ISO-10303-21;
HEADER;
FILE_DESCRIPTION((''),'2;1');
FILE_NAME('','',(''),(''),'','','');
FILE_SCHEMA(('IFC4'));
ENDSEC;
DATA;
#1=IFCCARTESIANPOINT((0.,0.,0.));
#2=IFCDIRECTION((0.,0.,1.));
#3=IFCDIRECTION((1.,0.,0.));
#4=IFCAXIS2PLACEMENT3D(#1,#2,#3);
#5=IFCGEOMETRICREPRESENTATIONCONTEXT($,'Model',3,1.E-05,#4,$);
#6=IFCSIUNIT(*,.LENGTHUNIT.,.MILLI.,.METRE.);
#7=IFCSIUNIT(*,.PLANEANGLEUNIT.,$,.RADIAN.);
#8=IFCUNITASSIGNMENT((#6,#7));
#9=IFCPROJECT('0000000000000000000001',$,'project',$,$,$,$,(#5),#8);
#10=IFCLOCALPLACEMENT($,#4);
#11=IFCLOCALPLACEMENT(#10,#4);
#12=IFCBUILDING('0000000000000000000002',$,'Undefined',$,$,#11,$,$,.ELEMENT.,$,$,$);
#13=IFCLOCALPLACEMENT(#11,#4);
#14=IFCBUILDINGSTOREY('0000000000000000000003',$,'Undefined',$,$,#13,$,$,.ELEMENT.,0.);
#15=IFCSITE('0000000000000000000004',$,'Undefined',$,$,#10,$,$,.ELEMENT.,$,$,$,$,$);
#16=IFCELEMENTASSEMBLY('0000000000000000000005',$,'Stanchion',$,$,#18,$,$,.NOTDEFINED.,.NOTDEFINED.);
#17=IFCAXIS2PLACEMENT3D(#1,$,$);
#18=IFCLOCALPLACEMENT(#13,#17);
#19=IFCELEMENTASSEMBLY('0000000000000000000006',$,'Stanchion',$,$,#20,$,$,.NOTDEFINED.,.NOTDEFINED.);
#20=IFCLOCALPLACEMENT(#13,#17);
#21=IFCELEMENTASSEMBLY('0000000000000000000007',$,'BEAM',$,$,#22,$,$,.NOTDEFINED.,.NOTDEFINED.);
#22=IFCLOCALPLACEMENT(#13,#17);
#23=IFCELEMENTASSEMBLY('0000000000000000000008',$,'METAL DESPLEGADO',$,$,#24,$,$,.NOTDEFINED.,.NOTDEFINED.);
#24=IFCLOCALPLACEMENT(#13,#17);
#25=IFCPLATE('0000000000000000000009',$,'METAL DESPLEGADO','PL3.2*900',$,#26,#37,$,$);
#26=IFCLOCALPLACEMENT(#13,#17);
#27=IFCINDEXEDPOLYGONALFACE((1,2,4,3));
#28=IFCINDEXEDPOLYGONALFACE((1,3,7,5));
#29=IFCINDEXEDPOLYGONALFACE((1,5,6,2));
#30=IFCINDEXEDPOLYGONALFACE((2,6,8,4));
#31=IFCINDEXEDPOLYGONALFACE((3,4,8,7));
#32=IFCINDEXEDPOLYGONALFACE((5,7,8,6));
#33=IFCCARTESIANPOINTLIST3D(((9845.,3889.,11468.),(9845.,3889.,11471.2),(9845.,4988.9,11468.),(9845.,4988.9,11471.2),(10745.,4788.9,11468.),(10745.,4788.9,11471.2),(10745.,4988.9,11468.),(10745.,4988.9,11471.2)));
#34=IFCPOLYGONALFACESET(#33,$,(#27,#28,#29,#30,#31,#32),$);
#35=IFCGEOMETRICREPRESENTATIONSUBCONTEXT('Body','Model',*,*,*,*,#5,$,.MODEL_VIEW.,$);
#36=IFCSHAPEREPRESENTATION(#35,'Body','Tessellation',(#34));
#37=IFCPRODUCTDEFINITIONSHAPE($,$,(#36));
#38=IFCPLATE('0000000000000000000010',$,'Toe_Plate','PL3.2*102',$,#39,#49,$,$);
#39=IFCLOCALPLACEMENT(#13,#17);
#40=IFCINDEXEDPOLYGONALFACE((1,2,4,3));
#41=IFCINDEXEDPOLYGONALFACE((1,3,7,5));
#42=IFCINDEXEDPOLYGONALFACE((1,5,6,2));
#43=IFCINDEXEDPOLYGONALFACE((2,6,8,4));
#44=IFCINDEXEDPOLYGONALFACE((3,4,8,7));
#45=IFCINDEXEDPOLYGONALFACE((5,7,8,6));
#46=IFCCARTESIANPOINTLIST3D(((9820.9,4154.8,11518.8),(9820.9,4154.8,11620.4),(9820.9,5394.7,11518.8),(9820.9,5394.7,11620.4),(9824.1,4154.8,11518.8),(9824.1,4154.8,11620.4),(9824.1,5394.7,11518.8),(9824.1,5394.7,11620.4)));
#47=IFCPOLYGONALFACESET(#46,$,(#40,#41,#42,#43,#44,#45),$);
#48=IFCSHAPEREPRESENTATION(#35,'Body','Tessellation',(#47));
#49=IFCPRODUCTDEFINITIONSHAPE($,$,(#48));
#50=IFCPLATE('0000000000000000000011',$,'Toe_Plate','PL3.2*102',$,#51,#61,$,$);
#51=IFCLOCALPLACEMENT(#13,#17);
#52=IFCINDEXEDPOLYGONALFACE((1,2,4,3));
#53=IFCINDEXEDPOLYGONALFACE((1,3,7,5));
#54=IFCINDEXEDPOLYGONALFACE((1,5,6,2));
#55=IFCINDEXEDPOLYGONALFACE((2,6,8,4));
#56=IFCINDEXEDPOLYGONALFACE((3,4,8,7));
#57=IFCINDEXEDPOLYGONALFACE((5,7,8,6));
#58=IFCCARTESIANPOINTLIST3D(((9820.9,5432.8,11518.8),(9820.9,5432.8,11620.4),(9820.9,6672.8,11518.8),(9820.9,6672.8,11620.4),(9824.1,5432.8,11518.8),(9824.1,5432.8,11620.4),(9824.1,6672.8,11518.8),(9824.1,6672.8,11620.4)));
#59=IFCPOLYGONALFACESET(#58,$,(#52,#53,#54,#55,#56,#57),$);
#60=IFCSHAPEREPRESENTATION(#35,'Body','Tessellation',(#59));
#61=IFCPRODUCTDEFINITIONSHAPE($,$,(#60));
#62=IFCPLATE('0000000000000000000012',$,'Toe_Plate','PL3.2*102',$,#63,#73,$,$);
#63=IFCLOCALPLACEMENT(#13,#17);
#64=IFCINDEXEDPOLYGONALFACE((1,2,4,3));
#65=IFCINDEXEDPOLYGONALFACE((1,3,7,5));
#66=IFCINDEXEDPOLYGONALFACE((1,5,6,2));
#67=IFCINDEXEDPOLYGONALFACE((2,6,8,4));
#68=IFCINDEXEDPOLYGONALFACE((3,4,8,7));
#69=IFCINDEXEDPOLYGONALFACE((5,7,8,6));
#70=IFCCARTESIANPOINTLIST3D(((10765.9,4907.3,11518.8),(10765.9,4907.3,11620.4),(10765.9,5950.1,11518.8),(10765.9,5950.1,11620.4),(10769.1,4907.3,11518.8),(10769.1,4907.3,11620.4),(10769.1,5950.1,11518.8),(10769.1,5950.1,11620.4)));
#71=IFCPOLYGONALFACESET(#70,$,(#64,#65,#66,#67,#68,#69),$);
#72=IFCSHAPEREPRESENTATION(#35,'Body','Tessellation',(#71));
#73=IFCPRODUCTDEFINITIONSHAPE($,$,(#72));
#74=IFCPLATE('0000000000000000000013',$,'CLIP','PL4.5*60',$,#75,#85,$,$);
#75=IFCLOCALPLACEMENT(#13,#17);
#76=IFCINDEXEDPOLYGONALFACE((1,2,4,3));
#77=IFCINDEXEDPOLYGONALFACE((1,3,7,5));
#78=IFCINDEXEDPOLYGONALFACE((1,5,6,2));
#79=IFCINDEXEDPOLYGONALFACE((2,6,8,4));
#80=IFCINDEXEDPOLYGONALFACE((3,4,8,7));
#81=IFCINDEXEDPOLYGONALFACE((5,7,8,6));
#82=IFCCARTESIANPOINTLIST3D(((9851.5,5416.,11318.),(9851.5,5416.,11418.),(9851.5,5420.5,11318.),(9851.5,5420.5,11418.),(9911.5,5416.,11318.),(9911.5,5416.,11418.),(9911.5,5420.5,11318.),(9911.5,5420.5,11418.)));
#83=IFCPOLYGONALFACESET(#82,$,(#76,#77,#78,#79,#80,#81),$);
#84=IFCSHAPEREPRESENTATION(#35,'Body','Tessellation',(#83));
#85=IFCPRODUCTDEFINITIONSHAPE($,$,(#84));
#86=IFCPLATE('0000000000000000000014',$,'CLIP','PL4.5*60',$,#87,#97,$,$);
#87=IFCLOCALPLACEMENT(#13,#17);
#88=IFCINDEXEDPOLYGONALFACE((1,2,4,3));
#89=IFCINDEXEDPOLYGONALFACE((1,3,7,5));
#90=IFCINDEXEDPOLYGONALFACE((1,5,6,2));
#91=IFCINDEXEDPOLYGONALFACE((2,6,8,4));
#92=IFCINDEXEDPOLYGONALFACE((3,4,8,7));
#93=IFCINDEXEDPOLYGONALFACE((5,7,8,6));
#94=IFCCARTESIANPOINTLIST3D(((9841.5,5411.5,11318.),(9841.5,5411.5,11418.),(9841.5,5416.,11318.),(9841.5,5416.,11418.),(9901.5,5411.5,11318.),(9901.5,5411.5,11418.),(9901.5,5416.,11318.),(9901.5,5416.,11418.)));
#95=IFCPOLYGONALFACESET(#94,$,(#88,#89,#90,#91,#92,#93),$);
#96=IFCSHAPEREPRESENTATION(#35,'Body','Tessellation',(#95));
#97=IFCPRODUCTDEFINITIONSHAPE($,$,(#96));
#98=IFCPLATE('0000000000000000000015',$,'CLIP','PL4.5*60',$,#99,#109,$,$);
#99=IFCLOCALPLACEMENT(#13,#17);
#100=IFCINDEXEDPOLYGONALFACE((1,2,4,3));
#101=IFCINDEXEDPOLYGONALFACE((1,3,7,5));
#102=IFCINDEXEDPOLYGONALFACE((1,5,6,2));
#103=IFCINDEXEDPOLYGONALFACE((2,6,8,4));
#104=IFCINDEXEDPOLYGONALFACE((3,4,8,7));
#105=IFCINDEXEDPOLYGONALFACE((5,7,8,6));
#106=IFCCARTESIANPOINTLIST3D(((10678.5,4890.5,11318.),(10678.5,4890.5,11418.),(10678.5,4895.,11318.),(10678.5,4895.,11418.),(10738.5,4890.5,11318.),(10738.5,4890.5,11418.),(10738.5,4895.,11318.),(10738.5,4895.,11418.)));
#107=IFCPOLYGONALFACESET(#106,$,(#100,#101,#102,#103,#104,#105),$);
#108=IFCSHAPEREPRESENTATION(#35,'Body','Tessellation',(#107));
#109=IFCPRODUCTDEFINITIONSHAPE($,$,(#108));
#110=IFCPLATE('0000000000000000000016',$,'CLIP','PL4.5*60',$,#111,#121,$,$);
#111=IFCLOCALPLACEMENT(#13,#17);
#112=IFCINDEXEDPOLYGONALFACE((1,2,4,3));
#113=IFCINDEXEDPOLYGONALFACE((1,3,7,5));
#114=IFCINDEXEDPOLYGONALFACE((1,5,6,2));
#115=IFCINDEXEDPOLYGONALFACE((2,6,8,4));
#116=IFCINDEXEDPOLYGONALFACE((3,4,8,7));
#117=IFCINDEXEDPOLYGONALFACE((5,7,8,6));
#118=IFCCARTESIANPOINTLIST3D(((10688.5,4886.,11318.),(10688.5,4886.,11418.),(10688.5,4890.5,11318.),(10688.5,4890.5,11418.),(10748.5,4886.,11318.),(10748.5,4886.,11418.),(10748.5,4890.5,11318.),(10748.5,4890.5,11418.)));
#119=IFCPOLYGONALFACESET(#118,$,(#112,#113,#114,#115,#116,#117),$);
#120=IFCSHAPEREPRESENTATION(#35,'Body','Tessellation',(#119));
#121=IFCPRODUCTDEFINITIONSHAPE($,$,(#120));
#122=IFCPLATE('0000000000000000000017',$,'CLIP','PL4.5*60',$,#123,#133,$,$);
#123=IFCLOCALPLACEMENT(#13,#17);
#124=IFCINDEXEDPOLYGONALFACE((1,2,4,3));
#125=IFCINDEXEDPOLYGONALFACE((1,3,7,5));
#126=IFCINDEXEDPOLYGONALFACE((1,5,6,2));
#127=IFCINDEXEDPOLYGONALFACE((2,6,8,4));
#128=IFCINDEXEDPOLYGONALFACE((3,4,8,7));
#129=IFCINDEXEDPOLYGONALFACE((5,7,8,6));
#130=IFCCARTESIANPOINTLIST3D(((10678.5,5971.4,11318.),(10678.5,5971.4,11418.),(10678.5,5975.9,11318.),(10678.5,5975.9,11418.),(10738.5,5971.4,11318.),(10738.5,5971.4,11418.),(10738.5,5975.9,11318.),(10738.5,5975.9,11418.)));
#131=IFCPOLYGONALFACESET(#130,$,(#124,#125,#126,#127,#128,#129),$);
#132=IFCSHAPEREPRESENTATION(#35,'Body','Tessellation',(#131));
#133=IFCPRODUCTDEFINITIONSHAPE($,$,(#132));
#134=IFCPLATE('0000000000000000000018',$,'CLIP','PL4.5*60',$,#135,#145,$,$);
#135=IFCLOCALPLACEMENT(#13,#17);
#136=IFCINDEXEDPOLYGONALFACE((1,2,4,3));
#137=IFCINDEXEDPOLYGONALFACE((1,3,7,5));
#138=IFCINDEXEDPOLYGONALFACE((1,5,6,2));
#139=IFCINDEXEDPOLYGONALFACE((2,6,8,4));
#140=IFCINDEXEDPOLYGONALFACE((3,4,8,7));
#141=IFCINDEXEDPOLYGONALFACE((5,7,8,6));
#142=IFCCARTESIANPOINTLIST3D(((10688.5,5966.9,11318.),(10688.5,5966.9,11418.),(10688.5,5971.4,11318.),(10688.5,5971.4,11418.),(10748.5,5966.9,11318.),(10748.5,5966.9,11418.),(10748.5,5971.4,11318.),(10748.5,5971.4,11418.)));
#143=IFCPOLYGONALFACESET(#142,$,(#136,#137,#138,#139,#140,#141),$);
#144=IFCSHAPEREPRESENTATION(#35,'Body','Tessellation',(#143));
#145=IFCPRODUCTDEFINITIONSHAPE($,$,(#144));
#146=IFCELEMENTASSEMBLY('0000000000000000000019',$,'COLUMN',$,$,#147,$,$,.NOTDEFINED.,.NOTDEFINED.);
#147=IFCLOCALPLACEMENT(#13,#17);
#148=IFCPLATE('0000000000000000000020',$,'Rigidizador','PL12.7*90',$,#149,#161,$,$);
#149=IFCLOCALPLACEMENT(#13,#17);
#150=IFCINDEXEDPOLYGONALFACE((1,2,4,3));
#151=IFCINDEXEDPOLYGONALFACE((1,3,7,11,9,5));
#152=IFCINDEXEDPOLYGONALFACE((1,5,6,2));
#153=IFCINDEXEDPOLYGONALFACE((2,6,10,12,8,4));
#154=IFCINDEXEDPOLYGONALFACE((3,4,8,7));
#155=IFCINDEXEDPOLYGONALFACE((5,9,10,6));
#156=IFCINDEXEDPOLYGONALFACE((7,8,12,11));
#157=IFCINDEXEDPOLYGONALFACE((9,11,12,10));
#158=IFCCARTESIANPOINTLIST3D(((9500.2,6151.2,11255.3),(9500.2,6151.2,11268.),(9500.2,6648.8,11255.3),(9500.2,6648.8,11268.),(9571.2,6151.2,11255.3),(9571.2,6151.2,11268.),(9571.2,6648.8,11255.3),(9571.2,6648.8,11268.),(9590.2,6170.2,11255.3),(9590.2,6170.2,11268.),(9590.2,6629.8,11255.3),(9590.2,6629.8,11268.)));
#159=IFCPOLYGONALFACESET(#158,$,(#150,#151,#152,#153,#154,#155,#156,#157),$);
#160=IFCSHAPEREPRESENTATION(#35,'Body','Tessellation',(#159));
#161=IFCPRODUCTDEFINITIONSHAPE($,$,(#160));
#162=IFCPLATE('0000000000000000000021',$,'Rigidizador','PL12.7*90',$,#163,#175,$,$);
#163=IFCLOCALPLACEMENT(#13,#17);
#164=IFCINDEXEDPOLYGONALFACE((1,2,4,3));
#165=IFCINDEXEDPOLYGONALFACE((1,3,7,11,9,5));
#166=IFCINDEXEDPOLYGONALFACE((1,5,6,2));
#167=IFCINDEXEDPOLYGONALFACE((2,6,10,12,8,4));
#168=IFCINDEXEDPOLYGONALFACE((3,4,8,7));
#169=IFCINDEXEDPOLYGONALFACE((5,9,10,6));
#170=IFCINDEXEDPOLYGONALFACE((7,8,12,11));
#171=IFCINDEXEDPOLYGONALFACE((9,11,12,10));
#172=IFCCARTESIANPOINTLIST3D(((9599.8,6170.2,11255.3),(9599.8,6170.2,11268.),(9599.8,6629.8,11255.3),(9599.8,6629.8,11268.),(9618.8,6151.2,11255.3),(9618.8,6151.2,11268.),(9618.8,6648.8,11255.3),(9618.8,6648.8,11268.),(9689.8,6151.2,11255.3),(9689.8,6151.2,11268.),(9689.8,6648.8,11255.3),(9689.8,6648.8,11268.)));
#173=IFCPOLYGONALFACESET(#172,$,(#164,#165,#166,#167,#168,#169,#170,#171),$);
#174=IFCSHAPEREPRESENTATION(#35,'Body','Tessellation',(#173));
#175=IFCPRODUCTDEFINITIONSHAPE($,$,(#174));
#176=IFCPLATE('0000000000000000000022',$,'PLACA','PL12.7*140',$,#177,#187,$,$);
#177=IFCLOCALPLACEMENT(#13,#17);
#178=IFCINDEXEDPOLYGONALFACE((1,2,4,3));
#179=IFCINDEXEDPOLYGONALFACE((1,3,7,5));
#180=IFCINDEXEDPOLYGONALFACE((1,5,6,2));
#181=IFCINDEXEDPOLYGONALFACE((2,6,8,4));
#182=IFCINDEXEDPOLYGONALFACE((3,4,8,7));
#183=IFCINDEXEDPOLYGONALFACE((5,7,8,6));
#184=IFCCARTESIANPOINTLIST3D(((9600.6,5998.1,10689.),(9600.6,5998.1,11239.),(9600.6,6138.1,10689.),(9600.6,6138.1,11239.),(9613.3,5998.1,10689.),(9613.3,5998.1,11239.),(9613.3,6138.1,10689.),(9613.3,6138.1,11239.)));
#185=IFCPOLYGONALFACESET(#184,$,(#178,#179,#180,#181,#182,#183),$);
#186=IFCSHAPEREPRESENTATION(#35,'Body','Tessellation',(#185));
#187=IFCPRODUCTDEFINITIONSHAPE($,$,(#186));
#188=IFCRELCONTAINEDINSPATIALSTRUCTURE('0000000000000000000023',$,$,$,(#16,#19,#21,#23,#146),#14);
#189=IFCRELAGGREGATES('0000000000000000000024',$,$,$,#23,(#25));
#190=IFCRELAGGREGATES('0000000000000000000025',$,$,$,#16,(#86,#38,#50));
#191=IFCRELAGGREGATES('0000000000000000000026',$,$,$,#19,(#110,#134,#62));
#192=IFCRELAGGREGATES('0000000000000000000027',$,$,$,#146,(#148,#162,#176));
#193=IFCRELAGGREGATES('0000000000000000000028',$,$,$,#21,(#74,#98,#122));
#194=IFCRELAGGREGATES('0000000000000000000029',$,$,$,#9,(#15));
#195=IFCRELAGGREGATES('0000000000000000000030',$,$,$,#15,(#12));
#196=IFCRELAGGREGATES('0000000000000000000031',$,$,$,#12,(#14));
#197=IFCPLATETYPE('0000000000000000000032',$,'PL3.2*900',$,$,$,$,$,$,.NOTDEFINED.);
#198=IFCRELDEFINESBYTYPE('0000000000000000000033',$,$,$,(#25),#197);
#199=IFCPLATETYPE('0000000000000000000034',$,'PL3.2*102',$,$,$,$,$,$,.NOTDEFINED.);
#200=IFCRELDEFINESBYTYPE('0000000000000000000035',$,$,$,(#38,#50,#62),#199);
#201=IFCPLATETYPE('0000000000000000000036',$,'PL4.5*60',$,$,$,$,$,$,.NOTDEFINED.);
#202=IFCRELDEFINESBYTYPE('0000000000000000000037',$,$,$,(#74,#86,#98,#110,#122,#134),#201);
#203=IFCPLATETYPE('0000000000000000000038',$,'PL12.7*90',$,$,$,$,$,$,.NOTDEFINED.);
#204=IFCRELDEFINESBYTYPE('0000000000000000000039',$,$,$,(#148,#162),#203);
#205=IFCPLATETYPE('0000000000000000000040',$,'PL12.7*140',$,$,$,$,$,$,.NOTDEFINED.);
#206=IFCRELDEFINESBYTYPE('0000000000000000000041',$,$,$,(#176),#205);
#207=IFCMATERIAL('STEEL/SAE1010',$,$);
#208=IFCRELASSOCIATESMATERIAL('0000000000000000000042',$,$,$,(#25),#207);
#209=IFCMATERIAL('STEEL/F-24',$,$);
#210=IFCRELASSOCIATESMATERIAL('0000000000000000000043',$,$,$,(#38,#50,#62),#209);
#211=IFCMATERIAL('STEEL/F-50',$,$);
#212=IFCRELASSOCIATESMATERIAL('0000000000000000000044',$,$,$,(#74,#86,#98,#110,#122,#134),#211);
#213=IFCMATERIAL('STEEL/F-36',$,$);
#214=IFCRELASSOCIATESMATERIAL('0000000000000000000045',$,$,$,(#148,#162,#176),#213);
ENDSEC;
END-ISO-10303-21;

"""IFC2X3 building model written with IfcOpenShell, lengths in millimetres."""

from ifc_helpers import new_model, si_unit, frame, origin_with_axes, place, context, subcontext, project, spatial, polyline, outline, extrude, material, type_object, element, aggregate, save


model = new_model("IFC2X3")

# Units and contexts
model_context = context("Model", 3, precision=1e-05, world=origin_with_axes())
body_context = subcontext(model_context, "Body", "Model", "MODEL_VIEW")
ifc_project = project(units=[si_unit("LENGTHUNIT", "METRE", prefix="MILLI"), si_unit("PLANEANGLEUNIT", "RADIAN")], contexts=[model_context])

# Site, building, storey
site_placement = place(None, origin_with_axes())
site = spatial("IfcSite", under=ifc_project, at=site_placement, Name="Undefined", CompositionType="ELEMENT")
building_placement = place(site_placement, origin_with_axes())
building = spatial("IfcBuilding", under=site, at=building_placement, Name="Undefined", CompositionType="ELEMENT")
storey_placement = place(building_placement, origin_with_axes())
storey = spatial("IfcBuildingStorey", under=building, at=storey_placement, Name="Undefined", CompositionType="ELEMENT", Elevation=0.0)

# Element assemblies
assembly_1_placement = place(storey_placement, origin_with_axes())
assembly_1 = element("IfcElementAssembly", 1, at=assembly_1_placement, inside=storey, Name="Stanchion", AssemblyPlace="NOTDEFINED", PredefinedType="NOTDEFINED")
ifc_material_1 = material(Name="STEEL/F-24")
assembly_2_placement = place(storey_placement, origin_with_axes())
assembly_2 = element("IfcElementAssembly", 2, at=assembly_2_placement, inside=storey, Name="Stanchion", AssemblyPlace="NOTDEFINED", PredefinedType="NOTDEFINED")

# Element assembly
assembly_3_placement = place(storey_placement, origin_with_axes())
assembly_3 = element("IfcElementAssembly", 3, at=assembly_3_placement, inside=storey, Name="BEAM", AssemblyPlace="NOTDEFINED", PredefinedType="NOTDEFINED")

# Element assembly, plate
assembly_4_placement = place(storey_placement, origin_with_axes())
assembly_4 = element("IfcElementAssembly", 4, at=assembly_4_placement, inside=storey, Name="METAL DESPLEGADO", AssemblyPlace="NOTDEFINED", PredefinedType="NOTDEFINED")
ifc_material_2 = material(Name="STEEL/SAE1010")
plate_type_1 = type_object("IfcPlateType", Name="PL3.2*900", PredefinedType="NOTDEFINED")
plate_1_placement = place(assembly_4_placement, frame((9845.0, 4988.9, 11469.6), z_axis=(0.0, 0.0, 1.0), x_axis=(0.0, -1.0, 0.0)))
plate_1 = element("IfcPlate", 5, at=plate_1_placement, type_object=plate_type_1, material=ifc_material_2, Name="METAL DESPLEGADO", Description="PL3.2*900", context=body_context, shape_type="SweptSolid", body=[
    extrude(outline(polyline([(0.0, 0.0), (1100.0, 0.0), (200.0, 900.0), (0.0, 900.0), (0.0, 0.0)])), frame((0.0, 0.0, -1.6), z_axis=(0.0, 0.0, 1.0), x_axis=(1.0, 0.0, 0.0)), (0.0, 0.0, 1.0), 3.2),
])
aggregate(assembly_4, [plate_1])

# Plates
plate_type_2 = type_object("IfcPlateType", Name="PL3.2*102", PredefinedType="NOTDEFINED")
plate_2_placement = place(assembly_1_placement, frame((9822.5, 5394.7, 11518.8), z_axis=(-1.0, 0.0, 0.0), x_axis=(0.0, -1.0, 0.0)))
plate_2 = element("IfcPlate", 6, at=plate_2_placement, type_object=plate_type_2, material=ifc_material_1, Name="Toe_Plate", Description="PL3.2*102", context=body_context, shape_type="SweptSolid", body=[
    extrude(outline(polyline([(0.0, 0.0), (1239.9, 0.0), (1239.9, 101.6), (0.0, 101.6), (0.0, 0.0)])), frame((0.0, 0.0, -1.6), z_axis=(0.0, 0.0, 1.0), x_axis=(1.0, 0.0, 0.0)), (0.0, 0.0, 1.0), 3.2),
])
plate_3_placement = place(assembly_1_placement, frame((9822.5, 6672.8, 11518.8), z_axis=(-1.0, 0.0, 0.0), x_axis=(0.0, -1.0, 0.0)))
plate_3 = element("IfcPlate", 7, at=plate_3_placement, type_object=plate_type_2, material=ifc_material_1, Name="Toe_Plate", Description="PL3.2*102", context=body_context, shape_type="SweptSolid", body=[
    extrude(outline(polyline([(0.0, 0.0), (1239.9, 0.0), (1239.9, 101.6), (0.0, 101.6), (0.0, 0.0)])), frame((0.0, 0.0, -1.6), z_axis=(0.0, 0.0, 1.0), x_axis=(1.0, 0.0, 0.0)), (0.0, 0.0, 1.0), 3.2),
])
plate_4_placement = place(assembly_2_placement, frame((10767.5, 5950.1, 11518.8), z_axis=(-1.0, 0.0, 0.0), x_axis=(0.0, -1.0, 0.0)))
plate_4 = element("IfcPlate", 8, at=plate_4_placement, type_object=plate_type_2, material=ifc_material_1, Name="Toe_Plate", Description="PL3.2*102", context=body_context, shape_type="SweptSolid", body=[
    extrude(outline(polyline([(0.0, 0.0), (1042.8, 0.0), (1042.8, 101.6), (0.0, 101.6), (0.0, 0.0)])), frame((0.0, 0.0, -1.6), z_axis=(0.0, 0.0, 1.0), x_axis=(1.0, 0.0, 0.0)), (0.0, 0.0, 1.0), 3.2),
])
ifc_material_3 = material(Name="STEEL/F-50")
plate_type_3 = type_object("IfcPlateType", Name="PL4.5*60", PredefinedType="NOTDEFINED")
plate_5_placement = place(assembly_3_placement, frame((9851.5, 5418.3, 11318.0), z_axis=(0.0, -1.0, 0.0), x_axis=(1.0, 0.0, 0.0)))
plate_5 = element("IfcPlate", 9, at=plate_5_placement, type_object=plate_type_3, material=ifc_material_3, Name="CLIP", Description="PL4.5*60", context=body_context, shape_type="SweptSolid", body=[
    extrude(outline(polyline([(0.0, 0.0), (60.0, 0.0), (60.0, 100.0), (0.0, 100.0), (0.0, 0.0)])), frame((0.0, 0.0, -2.2), z_axis=(0.0, 0.0, 1.0), x_axis=(1.0, 0.0, 0.0)), (0.0, 0.0, 1.0), 4.5),
])
plate_6_placement = place(assembly_1_placement, frame((9841.5, 5413.8, 11318.0), z_axis=(0.0, -1.0, 0.0), x_axis=(1.0, 0.0, 0.0)))
plate_6 = element("IfcPlate", 10, at=plate_6_placement, type_object=plate_type_3, material=ifc_material_3, Name="CLIP", Description="PL4.5*60", context=body_context, shape_type="SweptSolid", body=[
    extrude(outline(polyline([(0.0, 0.0), (60.0, 0.0), (60.0, 100.0), (0.0, 100.0), (0.0, 0.0)])), frame((0.0, 0.0, -2.2), z_axis=(0.0, 0.0, 1.0), x_axis=(1.0, 0.0, 0.0)), (0.0, 0.0, 1.0), 4.5),
])
aggregate(assembly_1, [plate_6, plate_2, plate_3])
plate_7_placement = place(assembly_3_placement, frame((10738.5, 4892.8, 11318.0), z_axis=(0.0, 1.0, 0.0), x_axis=(-1.0, 0.0, 0.0)))
plate_7 = element("IfcPlate", 11, at=plate_7_placement, type_object=plate_type_3, material=ifc_material_3, Name="CLIP", Description="PL4.5*60", context=body_context, shape_type="SweptSolid", body=[
    extrude(outline(polyline([(0.0, 0.0), (60.0, 0.0), (60.0, 100.0), (0.0, 100.0), (0.0, 0.0)])), frame((0.0, 0.0, -2.2), z_axis=(0.0, 0.0, 1.0), x_axis=(1.0, 0.0, 0.0)), (0.0, 0.0, 1.0), 4.5),
])
plate_8_placement = place(assembly_2_placement, frame((10748.5, 4888.3, 11318.0), z_axis=(0.0, 1.0, 0.0), x_axis=(-1.0, 0.0, 0.0)))
plate_8 = element("IfcPlate", 12, at=plate_8_placement, type_object=plate_type_3, material=ifc_material_3, Name="CLIP", Description="PL4.5*60", context=body_context, shape_type="SweptSolid", body=[
    extrude(outline(polyline([(0.0, 0.0), (60.0, 0.0), (60.0, 100.0), (0.0, 100.0), (0.0, 0.0)])), frame((0.0, 0.0, -2.2), z_axis=(0.0, 0.0, 1.0), x_axis=(1.0, 0.0, 0.0)), (0.0, 0.0, 1.0), 4.5),
])
plate_9_placement = place(assembly_3_placement, frame((10738.5, 5973.6, 11318.0), z_axis=(0.0, 1.0, 0.0), x_axis=(-1.0, 0.0, 0.0)))
plate_9 = element("IfcPlate", 13, at=plate_9_placement, type_object=plate_type_3, material=ifc_material_3, Name="CLIP", Description="PL4.5*60", context=body_context, shape_type="SweptSolid", body=[
    extrude(outline(polyline([(0.0, 0.0), (60.0, 0.0), (60.0, 100.0), (0.0, 100.0), (0.0, 0.0)])), frame((0.0, 0.0, -2.2), z_axis=(0.0, 0.0, 1.0), x_axis=(1.0, 0.0, 0.0)), (0.0, 0.0, 1.0), 4.5),
])
plate_10_placement = place(assembly_2_placement, frame((10748.5, 5969.1, 11318.0), z_axis=(0.0, 1.0, 0.0), x_axis=(-1.0, 0.0, 0.0)))
plate_10 = element("IfcPlate", 14, at=plate_10_placement, type_object=plate_type_3, material=ifc_material_3, Name="CLIP", Description="PL4.5*60", context=body_context, shape_type="SweptSolid", body=[
    extrude(outline(polyline([(0.0, 0.0), (60.0, 0.0), (60.0, 100.0), (0.0, 100.0), (0.0, 0.0)])), frame((0.0, 0.0, -2.2), z_axis=(0.0, 0.0, 1.0), x_axis=(1.0, 0.0, 0.0)), (0.0, 0.0, 1.0), 4.5),
])
aggregate(assembly_2, [plate_8, plate_10, plate_4])

# Shared definitions
ifc_material_4 = material(Name="STEEL/F-36")

# Element assembly, plates
assembly_5_placement = place(storey_placement, origin_with_axes())
assembly_5 = element("IfcElementAssembly", 15, at=assembly_5_placement, inside=storey, Name="COLUMN", AssemblyPlace="NOTDEFINED", PredefinedType="NOTDEFINED")
plate_type_4 = type_object("IfcPlateType", Name="PL12.7*90", PredefinedType="NOTDEFINED")
plate_11_placement = place(assembly_5_placement, frame((9590.2, 6151.2, 11261.6), z_axis=(0.0, 0.0, -1.0), x_axis=(-1.0, 0.0, 0.0)))
plate_11 = element("IfcPlate", 16, at=plate_11_placement, type_object=plate_type_4, material=ifc_material_4, Name="Rigidizador", Description="PL12.7*90", context=body_context, shape_type="SweptSolid", body=[
    extrude(outline(polyline([(0.0, 19.0), (19.0, 0.0), (90.0, 0.0), (90.0, 497.6), (19.0, 497.6), (0.0, 478.6), (0.0, 19.0)])), frame((0.0, 0.0, -6.3), z_axis=(0.0, 0.0, 1.0), x_axis=(1.0, 0.0, 0.0)), (0.0, 0.0, 1.0), 12.7),
])
plate_12_placement = place(assembly_5_placement, frame((9689.8, 6151.2, 11261.6), z_axis=(0.0, 0.0, -1.0), x_axis=(-1.0, 0.0, 0.0)))
plate_12 = element("IfcPlate", 17, at=plate_12_placement, type_object=plate_type_4, material=ifc_material_4, Name="Rigidizador", Description="PL12.7*90", context=body_context, shape_type="SweptSolid", body=[
    extrude(outline(polyline([(0.0, 0.0), (71.0, 0.0), (90.0, 19.0), (90.0, 478.6), (71.0, 497.6), (0.0, 497.6), (0.0, 0.0)])), frame((0.0, 0.0, -6.3), z_axis=(0.0, 0.0, 1.0), x_axis=(1.0, 0.0, 0.0)), (0.0, 0.0, 1.0), 12.7),
])
plate_type_5 = type_object("IfcPlateType", Name="PL12.7*140", PredefinedType="NOTDEFINED")
plate_13_placement = place(assembly_5_placement, frame((9606.9, 6138.1, 11239.0), z_axis=(-1.0, 0.0, 0.0), x_axis=(0.0, 0.0, -1.0)))
plate_13 = element("IfcPlate", 18, at=plate_13_placement, type_object=plate_type_5, material=ifc_material_4, Name="PLACA", Description="PL12.7*140", context=body_context, shape_type="SweptSolid", body=[
    extrude(outline(polyline([(0.0, 0.0), (550.0, 0.0), (550.0, 140.0), (0.0, 140.0), (0.0, 0.0)])), frame((0.0, 0.0, -6.3), z_axis=(0.0, 0.0, 1.0), x_axis=(1.0, 0.0, 0.0)), (0.0, 0.0, 1.0), 12.7),
])
aggregate(assembly_5, [plate_11, plate_12, plate_13])

aggregate(assembly_3, [plate_5, plate_7, plate_9])

save(model, "model.ifc")
